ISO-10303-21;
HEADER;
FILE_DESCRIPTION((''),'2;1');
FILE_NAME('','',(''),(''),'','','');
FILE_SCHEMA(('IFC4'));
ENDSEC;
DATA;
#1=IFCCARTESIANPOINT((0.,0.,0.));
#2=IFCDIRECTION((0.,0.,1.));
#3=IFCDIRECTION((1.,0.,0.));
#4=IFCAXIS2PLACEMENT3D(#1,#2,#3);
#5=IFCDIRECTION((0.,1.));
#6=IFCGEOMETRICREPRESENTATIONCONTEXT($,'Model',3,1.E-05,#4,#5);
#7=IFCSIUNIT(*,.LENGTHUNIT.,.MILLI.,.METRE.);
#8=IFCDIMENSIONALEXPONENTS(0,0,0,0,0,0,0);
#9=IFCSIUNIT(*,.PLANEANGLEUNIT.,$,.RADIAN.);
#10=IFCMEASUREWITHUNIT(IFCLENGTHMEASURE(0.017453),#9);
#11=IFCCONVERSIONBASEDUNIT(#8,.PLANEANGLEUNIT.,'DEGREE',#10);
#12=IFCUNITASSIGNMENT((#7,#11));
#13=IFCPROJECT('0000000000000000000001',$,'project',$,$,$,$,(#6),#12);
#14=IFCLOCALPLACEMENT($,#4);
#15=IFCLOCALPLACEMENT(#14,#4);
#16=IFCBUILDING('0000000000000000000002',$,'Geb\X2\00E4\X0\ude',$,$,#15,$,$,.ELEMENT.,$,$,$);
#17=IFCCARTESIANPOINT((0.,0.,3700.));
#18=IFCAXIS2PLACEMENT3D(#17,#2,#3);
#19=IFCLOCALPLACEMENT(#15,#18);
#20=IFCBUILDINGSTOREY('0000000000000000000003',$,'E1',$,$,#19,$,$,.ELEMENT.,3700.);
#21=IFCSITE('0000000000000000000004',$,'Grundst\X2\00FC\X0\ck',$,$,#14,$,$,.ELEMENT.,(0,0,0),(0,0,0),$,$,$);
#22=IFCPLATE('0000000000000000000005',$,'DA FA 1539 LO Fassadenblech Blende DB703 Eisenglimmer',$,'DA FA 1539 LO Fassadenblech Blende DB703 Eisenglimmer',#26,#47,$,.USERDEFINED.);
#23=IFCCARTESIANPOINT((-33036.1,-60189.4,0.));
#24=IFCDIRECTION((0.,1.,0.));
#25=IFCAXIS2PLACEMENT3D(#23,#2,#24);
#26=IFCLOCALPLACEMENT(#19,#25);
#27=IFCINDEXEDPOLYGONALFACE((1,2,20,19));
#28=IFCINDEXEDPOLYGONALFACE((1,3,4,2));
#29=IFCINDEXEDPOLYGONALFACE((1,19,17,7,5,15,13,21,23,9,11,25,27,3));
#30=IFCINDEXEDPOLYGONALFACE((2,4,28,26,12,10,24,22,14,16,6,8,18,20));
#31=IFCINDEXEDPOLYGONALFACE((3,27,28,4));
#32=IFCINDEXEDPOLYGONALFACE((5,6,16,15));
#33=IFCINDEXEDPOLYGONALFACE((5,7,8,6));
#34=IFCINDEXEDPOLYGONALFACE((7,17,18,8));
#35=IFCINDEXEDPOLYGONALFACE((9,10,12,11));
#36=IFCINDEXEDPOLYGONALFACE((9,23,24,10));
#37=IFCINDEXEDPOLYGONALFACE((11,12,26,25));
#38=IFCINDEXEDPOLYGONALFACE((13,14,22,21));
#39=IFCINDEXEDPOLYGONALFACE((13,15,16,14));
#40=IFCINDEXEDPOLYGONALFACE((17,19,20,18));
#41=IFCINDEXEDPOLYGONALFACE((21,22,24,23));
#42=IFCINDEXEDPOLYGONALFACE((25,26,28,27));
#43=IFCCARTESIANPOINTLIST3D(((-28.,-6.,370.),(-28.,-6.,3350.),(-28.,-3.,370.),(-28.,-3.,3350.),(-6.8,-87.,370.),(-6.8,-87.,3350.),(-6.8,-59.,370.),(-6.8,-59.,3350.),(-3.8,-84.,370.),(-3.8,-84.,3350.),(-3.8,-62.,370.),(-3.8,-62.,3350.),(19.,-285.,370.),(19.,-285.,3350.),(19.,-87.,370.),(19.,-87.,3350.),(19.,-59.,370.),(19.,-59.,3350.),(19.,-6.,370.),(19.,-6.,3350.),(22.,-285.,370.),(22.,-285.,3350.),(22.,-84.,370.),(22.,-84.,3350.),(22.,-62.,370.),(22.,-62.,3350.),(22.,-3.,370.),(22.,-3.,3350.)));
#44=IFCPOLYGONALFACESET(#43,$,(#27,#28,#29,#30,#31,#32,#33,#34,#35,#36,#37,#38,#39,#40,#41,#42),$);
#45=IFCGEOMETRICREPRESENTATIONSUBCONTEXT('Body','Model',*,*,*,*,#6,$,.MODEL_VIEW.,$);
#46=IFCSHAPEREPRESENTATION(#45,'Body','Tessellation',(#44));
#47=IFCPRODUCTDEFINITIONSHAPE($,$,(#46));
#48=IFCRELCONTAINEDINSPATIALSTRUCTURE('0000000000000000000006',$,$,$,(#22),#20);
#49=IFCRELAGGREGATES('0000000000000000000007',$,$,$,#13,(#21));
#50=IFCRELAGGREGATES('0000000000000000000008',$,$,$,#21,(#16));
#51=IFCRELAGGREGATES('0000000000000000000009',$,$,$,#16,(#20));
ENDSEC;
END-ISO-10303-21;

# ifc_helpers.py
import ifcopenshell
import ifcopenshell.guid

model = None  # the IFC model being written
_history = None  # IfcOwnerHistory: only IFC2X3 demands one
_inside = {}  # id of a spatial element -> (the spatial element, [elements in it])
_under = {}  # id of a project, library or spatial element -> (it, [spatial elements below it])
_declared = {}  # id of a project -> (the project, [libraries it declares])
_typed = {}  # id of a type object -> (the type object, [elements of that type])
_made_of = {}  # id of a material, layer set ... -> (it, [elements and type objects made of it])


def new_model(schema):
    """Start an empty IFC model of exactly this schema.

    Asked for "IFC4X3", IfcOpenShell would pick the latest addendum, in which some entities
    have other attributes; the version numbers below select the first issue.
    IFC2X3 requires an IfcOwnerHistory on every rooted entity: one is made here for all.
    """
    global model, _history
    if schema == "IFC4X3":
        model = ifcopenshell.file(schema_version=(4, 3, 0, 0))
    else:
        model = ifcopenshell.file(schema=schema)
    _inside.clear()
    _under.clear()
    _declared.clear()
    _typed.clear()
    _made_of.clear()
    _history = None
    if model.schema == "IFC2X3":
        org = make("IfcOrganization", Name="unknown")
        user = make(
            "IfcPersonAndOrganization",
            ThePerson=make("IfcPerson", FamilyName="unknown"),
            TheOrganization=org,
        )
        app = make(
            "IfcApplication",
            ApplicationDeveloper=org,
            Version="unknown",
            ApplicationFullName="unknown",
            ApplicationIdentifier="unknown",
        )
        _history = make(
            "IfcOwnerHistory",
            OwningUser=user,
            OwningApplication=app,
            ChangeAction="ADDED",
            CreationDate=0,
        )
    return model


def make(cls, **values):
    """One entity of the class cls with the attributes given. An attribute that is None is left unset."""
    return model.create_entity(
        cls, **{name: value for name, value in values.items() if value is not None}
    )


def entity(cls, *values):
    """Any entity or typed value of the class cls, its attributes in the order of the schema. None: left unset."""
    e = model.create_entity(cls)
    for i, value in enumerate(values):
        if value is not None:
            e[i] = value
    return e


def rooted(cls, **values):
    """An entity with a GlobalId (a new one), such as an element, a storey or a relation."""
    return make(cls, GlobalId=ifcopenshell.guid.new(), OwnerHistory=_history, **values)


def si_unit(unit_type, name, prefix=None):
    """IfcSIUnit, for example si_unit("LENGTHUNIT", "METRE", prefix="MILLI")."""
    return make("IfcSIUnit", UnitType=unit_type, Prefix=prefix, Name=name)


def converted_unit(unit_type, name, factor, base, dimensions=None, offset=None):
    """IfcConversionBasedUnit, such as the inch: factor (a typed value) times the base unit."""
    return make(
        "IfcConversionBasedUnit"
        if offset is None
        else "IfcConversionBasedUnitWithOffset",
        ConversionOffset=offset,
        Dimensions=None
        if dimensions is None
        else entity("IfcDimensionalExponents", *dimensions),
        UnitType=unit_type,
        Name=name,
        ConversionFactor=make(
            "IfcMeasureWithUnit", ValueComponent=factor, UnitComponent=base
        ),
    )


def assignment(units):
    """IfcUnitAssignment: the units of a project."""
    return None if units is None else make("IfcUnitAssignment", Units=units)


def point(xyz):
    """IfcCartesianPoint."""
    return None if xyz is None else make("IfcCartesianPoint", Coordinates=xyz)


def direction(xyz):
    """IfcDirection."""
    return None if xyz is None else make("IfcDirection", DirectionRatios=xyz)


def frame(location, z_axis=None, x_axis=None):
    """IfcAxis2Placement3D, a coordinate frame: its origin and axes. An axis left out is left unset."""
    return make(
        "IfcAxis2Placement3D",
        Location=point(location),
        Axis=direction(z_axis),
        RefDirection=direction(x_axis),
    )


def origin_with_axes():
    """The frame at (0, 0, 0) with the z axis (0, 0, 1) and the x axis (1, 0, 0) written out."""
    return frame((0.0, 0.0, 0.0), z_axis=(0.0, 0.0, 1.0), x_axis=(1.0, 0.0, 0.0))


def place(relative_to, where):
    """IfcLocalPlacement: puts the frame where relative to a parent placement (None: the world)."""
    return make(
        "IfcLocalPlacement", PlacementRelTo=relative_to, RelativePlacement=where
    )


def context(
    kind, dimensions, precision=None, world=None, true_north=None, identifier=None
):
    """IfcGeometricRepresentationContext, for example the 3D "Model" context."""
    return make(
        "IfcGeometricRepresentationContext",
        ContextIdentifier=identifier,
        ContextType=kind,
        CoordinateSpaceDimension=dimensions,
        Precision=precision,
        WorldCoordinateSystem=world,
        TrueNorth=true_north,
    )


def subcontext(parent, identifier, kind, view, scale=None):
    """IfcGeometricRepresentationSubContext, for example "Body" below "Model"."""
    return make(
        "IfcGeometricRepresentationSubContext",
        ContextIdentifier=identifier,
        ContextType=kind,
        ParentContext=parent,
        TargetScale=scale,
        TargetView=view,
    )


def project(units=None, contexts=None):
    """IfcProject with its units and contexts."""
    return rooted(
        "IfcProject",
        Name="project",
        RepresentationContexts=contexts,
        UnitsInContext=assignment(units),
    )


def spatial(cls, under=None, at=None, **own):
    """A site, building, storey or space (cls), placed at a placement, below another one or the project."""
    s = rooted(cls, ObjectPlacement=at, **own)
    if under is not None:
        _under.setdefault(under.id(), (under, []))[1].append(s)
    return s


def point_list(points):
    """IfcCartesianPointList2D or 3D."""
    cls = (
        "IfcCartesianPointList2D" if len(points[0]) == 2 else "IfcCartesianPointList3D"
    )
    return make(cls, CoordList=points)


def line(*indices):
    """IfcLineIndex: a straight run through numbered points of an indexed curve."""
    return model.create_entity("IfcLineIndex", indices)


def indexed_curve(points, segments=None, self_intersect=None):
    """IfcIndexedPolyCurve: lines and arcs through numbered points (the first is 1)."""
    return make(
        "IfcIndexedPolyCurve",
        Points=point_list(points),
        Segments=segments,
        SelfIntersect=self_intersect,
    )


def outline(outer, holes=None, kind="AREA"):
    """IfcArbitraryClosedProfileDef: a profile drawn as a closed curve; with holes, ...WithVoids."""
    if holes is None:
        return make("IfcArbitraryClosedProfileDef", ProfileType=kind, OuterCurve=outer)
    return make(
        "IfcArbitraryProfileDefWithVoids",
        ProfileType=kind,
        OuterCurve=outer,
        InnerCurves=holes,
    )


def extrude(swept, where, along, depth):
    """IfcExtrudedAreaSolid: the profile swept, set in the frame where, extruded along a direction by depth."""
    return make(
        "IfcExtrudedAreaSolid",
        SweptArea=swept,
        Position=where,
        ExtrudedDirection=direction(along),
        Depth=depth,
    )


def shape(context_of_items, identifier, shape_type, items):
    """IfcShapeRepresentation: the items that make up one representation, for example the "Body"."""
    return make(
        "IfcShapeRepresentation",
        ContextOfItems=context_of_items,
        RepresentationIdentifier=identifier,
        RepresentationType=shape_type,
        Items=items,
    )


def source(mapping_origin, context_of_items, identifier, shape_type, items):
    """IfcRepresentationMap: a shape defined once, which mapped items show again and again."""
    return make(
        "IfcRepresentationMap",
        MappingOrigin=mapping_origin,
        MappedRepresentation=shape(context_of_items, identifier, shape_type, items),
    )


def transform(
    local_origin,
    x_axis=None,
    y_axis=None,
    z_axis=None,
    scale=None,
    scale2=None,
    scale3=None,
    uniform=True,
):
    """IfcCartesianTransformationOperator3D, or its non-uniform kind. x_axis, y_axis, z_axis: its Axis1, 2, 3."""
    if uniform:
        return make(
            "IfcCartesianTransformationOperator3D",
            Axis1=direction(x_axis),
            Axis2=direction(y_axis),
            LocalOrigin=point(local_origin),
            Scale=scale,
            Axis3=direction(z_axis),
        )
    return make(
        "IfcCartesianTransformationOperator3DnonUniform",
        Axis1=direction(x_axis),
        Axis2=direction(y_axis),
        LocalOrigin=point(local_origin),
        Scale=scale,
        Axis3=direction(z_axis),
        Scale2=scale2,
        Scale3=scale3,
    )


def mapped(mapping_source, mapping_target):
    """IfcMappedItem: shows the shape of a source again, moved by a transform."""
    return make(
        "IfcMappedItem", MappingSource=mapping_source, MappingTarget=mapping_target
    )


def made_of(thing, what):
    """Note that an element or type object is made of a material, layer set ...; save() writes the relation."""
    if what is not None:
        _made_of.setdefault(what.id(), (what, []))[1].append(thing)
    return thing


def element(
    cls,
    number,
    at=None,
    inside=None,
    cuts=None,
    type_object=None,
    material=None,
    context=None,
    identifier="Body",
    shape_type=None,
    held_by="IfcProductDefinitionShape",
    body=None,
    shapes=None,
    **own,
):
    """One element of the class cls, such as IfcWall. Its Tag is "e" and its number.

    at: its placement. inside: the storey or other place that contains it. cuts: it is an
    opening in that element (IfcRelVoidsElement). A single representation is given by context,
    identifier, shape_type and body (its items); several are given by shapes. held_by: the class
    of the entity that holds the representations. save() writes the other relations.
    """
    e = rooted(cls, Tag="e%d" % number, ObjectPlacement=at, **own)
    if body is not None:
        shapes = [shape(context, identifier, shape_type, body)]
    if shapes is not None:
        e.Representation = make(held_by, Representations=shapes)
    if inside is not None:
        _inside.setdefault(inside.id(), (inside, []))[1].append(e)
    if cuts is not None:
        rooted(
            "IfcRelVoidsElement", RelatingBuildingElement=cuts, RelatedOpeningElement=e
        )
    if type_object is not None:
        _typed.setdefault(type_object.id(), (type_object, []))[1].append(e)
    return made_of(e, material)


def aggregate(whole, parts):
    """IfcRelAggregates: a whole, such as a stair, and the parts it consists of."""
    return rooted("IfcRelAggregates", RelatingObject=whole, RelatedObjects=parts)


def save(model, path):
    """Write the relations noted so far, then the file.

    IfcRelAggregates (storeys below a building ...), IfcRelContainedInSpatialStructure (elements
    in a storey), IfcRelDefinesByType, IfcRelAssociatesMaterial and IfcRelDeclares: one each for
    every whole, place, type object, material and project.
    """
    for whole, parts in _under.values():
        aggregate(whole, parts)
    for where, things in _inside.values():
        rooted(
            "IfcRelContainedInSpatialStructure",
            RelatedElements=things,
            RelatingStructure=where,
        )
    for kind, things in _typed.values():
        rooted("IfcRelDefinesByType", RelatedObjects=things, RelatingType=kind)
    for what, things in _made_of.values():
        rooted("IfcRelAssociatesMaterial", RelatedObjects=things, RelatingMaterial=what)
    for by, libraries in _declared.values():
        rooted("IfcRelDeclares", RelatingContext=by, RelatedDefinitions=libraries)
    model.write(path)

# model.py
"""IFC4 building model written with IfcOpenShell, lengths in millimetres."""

from ifc_helpers import new_model, entity, si_unit, converted_unit, direction, frame, origin_with_axes, place, context, subcontext, project, spatial, line, indexed_curve, outline, extrude, source, transform, mapped, element, save


model = new_model("IFC4")

# Units and contexts
model_context = context("Model", 3, precision=1e-05, world=origin_with_axes(), true_north=direction((0.0, 1.0)))
body_context = subcontext(model_context, "Body", "Model", "MODEL_VIEW")
ifc_project = project(units=[si_unit("LENGTHUNIT", "METRE", prefix="MILLI"), converted_unit("PLANEANGLEUNIT", "DEGREE", entity("IfcLengthMeasure", 0.017453), si_unit("PLANEANGLEUNIT", "RADIAN"), dimensions=[0, 0, 0, 0, 0, 0, 0])], contexts=[model_context])

# Site, building, storey
site_placement = place(None, origin_with_axes())
site = spatial("IfcSite", under=ifc_project, at=site_placement, Name="Grundstück", CompositionType="ELEMENT", RefLatitude=(0, 0, 0), RefLongitude=(0, 0, 0))
building_placement = place(site_placement, origin_with_axes())
building = spatial("IfcBuilding", under=site, at=building_placement, Name="Gebäude", CompositionType="ELEMENT")
storey_placement = place(building_placement, frame((0.0, 0.0, 3700.0), z_axis=(0.0, 0.0, 1.0), x_axis=(1.0, 0.0, 0.0)))
storey = spatial("IfcBuildingStorey", under=building, at=storey_placement, Name="E1", CompositionType="ELEMENT", Elevation=3700.0)

# Plate
shared_shape_1 = source(origin_with_axes(), body_context, "Body", "SweptSolid", [
    extrude(outline(indexed_curve([(22.0, 285.0), (22.0, 84.0), (-3.8, 84.0), (-3.8, 62.0), (22.0, 62.0), (22.0, 3.0), (-28.0, 3.0), (-28.0, 6.0), (19.0, 6.0), (19.0, 59.0), (-6.8, 59.0), (-6.8, 87.0), (19.0, 87.0), (19.0, 285.0)], segments=[line(1, 2), line(2, 3), line(3, 4), line(4, 5), line(5, 6), line(6, 7), line(7, 8), line(8, 9), line(9, 10), line(10, 11), line(11, 12), line(12, 13), line(13, 14), line(14, 1)])), frame((0.0, 0.0, 370.0), z_axis=(0.0, 0.0, 1.0), x_axis=(1.0, 0.0, 0.0)), (0.0, 0.0, 1.0), 2980.0),
])
plate_1_placement = place(storey_placement, frame((-33036.1, -60189.4, 0.0), z_axis=(0.0, 0.0, 1.0), x_axis=(0.0, 1.0, 0.0)))
element("IfcPlate", 1, at=plate_1_placement, inside=storey, Name="DA FA 1539 LO Fassadenblech Blende DB703 Eisenglimmer", ObjectType="DA FA 1539 LO Fassadenblech Blende DB703 Eisenglimmer", PredefinedType="USERDEFINED", context=body_context, shape_type="MappedRepresentation", body=[
    mapped(shared_shape_1, transform((0.0, 0.0, 0.0), x_axis=(1.0, 0.0, 0.0), y_axis=(0.0, -1.0, 0.0), z_axis=(0.0, 0.0, 1.0), scale=1.0)),
])

save(model, "model.ifc")
